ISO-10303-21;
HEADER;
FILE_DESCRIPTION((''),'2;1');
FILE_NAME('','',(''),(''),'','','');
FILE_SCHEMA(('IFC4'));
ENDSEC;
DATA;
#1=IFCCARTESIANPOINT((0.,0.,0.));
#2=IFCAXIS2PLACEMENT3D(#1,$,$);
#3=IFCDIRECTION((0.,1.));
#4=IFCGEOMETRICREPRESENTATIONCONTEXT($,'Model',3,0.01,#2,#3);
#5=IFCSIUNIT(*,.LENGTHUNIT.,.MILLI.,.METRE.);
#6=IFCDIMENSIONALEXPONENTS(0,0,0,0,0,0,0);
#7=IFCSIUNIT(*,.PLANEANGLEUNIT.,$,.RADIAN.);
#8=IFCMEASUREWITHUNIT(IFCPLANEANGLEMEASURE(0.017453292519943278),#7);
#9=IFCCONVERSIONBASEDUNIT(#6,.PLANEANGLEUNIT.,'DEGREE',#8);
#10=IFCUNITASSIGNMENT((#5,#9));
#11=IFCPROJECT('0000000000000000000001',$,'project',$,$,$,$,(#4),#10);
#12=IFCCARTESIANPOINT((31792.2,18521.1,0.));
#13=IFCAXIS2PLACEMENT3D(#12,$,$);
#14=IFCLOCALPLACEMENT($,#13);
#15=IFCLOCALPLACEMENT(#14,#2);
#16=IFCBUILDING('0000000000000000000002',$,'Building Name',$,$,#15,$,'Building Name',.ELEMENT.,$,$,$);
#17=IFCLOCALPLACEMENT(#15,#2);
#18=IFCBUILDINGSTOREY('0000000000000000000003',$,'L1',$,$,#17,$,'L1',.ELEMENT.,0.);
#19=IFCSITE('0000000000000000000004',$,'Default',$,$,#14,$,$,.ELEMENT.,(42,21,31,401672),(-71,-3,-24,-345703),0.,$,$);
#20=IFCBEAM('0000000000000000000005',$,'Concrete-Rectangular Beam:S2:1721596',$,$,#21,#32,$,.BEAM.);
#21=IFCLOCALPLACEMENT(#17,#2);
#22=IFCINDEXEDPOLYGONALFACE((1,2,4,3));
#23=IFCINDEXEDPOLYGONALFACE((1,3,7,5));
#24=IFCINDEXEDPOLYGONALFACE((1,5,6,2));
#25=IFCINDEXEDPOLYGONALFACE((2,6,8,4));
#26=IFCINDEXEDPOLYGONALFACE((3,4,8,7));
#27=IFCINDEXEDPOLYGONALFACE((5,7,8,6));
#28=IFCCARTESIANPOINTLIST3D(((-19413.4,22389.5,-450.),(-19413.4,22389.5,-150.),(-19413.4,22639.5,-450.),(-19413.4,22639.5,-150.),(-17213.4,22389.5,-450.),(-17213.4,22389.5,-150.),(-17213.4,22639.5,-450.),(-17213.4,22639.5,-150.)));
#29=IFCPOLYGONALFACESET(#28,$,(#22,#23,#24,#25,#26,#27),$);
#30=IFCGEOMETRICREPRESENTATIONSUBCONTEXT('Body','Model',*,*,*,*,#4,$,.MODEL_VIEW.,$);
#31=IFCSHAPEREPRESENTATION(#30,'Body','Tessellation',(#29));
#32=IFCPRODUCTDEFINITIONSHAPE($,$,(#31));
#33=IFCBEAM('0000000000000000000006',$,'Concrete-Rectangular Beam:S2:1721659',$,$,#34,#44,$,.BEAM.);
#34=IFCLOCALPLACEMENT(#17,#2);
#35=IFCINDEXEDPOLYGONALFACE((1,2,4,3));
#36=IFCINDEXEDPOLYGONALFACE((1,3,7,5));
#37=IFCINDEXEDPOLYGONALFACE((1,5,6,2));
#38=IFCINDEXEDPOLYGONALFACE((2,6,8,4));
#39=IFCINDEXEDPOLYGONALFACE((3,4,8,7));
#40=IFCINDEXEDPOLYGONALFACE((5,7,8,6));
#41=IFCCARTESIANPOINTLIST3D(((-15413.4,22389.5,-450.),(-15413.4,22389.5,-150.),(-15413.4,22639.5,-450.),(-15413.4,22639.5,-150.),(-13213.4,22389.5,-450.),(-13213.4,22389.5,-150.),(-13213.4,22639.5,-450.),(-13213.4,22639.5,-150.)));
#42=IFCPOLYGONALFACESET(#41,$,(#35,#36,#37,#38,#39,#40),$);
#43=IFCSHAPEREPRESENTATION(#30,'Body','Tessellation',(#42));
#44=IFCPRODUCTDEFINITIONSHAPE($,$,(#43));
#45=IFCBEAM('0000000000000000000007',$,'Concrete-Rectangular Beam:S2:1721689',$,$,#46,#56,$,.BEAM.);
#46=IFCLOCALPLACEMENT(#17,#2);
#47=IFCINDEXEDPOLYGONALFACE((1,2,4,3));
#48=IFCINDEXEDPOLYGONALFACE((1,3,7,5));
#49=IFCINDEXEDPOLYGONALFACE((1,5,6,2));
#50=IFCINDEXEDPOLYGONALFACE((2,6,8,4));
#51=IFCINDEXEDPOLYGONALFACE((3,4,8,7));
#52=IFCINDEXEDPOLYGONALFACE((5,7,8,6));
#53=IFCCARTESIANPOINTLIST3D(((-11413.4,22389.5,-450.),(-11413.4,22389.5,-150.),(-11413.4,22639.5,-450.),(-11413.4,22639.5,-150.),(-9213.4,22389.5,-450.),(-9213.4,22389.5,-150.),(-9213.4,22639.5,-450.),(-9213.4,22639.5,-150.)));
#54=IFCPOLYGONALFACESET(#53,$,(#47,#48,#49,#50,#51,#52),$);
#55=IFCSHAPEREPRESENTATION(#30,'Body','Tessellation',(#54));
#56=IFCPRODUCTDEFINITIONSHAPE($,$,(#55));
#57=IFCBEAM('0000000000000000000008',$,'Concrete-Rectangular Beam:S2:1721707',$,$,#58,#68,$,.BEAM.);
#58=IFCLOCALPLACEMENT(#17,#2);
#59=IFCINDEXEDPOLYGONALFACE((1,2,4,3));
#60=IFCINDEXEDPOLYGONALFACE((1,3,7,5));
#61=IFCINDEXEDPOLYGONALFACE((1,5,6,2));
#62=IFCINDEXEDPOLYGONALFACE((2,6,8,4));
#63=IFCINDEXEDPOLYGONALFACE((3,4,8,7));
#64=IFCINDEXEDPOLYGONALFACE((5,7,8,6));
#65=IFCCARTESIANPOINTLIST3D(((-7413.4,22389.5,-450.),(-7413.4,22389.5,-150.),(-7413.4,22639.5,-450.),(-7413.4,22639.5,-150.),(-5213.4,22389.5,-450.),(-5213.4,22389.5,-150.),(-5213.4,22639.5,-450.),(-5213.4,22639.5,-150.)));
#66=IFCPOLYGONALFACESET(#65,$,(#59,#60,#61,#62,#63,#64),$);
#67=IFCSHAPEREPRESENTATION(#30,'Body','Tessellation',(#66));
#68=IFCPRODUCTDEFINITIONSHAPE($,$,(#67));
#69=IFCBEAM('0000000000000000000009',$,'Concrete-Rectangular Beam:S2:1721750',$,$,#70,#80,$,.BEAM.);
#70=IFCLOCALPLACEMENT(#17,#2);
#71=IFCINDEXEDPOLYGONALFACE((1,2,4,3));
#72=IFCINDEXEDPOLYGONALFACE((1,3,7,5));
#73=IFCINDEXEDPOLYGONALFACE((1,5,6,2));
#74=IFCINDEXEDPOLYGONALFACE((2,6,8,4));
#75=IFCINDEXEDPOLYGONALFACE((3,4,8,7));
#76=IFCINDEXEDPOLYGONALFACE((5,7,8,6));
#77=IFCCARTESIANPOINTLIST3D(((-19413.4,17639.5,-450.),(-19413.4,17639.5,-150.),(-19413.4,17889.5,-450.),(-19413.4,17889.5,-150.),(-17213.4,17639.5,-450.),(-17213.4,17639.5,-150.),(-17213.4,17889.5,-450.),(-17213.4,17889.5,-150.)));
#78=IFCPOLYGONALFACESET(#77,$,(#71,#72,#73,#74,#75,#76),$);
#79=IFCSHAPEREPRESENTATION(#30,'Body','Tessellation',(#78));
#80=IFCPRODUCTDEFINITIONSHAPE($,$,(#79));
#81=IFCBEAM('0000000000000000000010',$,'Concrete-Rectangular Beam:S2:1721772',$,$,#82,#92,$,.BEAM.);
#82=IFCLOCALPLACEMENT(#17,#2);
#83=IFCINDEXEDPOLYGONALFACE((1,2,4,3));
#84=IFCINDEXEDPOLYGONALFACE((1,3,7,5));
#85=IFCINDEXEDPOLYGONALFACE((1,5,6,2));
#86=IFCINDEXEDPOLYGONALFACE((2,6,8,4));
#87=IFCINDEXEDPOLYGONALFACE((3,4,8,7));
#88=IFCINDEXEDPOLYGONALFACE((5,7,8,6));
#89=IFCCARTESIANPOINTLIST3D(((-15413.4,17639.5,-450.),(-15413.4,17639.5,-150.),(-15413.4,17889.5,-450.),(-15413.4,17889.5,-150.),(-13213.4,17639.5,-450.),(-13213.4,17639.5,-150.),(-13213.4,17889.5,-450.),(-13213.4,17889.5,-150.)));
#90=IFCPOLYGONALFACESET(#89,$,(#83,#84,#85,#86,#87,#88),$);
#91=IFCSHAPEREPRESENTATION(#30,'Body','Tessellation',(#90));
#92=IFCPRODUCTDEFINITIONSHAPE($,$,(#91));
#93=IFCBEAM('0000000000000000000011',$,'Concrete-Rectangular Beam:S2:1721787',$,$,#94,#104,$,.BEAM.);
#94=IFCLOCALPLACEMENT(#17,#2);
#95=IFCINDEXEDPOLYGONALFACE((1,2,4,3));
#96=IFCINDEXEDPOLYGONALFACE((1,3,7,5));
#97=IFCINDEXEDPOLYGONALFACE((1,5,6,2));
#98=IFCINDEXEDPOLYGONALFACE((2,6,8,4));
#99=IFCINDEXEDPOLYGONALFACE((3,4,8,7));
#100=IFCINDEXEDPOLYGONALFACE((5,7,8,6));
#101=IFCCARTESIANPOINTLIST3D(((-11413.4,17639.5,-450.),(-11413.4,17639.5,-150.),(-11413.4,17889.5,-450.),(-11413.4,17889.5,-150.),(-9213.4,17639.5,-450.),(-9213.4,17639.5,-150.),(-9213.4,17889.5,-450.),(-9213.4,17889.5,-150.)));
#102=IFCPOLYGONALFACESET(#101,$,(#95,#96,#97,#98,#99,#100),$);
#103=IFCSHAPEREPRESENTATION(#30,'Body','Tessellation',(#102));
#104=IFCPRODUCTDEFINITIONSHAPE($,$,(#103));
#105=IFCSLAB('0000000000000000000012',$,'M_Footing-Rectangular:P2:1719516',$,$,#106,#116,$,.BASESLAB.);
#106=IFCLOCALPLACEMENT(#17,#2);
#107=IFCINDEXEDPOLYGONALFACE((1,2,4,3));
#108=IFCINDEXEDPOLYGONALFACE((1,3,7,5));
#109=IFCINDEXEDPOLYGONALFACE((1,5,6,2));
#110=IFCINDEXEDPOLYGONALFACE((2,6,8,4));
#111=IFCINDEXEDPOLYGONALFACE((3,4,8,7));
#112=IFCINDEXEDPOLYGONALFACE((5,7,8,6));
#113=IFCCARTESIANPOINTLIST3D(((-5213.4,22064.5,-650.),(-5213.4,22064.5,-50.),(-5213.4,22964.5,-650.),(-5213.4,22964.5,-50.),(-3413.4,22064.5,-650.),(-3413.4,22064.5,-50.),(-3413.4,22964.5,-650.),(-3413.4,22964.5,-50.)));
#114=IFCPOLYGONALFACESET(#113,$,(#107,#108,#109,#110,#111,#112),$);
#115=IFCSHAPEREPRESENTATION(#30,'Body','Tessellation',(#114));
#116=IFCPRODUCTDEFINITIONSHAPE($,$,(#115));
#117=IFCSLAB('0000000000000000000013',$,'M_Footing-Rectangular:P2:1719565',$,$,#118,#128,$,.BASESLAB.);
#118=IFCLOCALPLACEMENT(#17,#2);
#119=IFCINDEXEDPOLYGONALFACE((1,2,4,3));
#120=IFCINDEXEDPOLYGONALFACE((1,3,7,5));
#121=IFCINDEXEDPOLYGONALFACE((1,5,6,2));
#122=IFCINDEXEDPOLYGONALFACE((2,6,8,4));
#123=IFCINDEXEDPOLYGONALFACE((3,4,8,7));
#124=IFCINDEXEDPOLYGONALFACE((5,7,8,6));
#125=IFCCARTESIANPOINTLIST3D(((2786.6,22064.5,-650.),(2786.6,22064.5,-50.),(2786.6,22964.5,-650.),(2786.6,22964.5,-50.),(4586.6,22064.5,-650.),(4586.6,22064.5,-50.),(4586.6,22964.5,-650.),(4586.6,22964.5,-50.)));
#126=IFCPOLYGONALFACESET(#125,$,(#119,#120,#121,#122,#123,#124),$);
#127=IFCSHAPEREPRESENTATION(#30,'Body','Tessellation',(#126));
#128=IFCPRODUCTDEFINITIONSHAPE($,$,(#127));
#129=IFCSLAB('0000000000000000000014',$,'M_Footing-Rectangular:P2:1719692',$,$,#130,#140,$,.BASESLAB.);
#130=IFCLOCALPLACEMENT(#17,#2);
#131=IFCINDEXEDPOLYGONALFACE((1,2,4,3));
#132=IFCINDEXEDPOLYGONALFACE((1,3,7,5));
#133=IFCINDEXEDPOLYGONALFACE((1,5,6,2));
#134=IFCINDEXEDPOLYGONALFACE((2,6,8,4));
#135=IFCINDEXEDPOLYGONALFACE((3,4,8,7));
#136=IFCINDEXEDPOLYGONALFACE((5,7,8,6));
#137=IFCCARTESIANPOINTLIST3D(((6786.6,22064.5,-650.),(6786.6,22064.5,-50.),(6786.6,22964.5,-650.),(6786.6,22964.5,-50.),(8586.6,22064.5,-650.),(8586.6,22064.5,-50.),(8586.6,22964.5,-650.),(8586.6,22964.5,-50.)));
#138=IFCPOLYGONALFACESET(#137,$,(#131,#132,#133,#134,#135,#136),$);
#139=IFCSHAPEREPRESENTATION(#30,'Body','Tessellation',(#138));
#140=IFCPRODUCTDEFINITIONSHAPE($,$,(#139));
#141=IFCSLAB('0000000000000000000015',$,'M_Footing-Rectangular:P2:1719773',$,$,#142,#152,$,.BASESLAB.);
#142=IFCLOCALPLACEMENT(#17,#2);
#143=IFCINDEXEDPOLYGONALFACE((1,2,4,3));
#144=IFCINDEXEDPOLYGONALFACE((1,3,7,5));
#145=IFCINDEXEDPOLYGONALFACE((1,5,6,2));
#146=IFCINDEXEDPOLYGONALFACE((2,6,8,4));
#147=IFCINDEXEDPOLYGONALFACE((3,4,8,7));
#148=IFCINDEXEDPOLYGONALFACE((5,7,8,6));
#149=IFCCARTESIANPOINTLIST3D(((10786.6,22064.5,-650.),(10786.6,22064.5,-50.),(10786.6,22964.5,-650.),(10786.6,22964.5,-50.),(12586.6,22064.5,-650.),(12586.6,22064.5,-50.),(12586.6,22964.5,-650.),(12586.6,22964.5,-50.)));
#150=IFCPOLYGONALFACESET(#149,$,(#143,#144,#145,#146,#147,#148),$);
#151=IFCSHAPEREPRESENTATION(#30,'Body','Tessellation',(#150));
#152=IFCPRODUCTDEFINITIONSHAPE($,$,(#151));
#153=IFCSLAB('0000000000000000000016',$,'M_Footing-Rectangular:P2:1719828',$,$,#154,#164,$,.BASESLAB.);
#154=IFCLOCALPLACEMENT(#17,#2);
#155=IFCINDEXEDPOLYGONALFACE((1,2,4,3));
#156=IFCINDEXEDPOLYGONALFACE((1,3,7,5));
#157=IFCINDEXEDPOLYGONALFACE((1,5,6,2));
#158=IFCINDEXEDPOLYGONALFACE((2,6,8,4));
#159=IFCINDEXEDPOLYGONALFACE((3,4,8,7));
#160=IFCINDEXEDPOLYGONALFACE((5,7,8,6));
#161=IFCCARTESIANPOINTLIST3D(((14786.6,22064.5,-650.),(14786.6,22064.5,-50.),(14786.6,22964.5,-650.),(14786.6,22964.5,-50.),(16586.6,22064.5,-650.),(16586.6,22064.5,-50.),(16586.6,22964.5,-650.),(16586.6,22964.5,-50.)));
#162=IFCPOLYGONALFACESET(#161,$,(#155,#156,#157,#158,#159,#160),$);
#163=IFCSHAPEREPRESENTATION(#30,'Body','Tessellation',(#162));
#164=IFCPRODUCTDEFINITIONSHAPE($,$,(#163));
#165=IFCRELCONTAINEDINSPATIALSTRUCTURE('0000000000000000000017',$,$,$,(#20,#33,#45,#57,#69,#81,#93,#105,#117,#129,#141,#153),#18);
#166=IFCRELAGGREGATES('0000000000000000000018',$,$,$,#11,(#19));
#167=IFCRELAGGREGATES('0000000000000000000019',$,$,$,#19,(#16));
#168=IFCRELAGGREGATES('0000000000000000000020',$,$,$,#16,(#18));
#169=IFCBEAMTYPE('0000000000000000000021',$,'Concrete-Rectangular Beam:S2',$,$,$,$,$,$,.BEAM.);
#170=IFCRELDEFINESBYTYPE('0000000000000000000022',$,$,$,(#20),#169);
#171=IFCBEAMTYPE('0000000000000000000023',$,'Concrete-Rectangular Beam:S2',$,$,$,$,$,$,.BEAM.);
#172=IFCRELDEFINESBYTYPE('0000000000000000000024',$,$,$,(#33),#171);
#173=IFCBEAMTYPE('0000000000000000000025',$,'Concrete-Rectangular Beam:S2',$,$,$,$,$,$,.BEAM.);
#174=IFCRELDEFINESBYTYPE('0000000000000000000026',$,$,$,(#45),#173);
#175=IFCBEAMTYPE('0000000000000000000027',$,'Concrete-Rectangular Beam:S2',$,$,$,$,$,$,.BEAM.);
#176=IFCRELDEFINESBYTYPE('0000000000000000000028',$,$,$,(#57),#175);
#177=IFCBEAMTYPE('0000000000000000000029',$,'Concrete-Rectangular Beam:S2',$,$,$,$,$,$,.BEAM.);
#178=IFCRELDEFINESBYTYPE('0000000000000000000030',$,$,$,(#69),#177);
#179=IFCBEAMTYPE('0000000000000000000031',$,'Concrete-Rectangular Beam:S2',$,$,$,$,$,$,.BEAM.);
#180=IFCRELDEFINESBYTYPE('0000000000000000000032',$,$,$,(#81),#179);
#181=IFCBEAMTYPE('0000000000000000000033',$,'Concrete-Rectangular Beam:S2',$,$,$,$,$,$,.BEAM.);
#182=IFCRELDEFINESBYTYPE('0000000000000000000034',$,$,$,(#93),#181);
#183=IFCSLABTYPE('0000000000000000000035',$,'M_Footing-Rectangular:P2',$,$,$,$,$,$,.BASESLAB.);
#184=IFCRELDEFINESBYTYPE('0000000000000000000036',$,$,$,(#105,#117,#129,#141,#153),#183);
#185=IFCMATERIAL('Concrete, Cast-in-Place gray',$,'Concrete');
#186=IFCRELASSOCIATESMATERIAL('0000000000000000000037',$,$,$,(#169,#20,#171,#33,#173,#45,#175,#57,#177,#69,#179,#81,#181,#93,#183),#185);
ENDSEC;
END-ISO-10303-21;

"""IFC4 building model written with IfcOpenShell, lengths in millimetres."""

from ifc_helpers import new_model, entity, si_unit, converted_unit, direction, frame, origin, place, context, subcontext, project, spatial, indexed_curve, outline, extrude, source, transform, mapped, material, type_object, type_shapes, element, save


model = new_model("IFC4")

# Units and contexts
model_context = context("Model", 3, precision=0.01, world=origin(), true_north=direction((0.0, 1.0)))
body_context = subcontext(model_context, "Body", "Model", "MODEL_VIEW")
ifc_project = project(units=[si_unit("LENGTHUNIT", "METRE", prefix="MILLI"), converted_unit("PLANEANGLEUNIT", "DEGREE", entity("IfcPlaneAngleMeasure", 0.017453292519943278), si_unit("PLANEANGLEUNIT", "RADIAN"), dimensions=[0, 0, 0, 0, 0, 0, 0])], contexts=[model_context])

# Site, building, storey
site_placement = place(None, frame((31792.2, 18521.1, 0.0)))
site = spatial("IfcSite", under=ifc_project, at=site_placement, Name="Default", CompositionType="ELEMENT", RefLatitude=(42, 21, 31, 401672), RefLongitude=(-71, -3, -24, -345703), RefElevation=0.0)
building_placement = place(site_placement, origin())
building = spatial("IfcBuilding", under=site, at=building_placement, Name="Building Name", LongName="Building Name", CompositionType="ELEMENT")
storey_placement = place(building_placement, origin())
storey = spatial("IfcBuildingStorey", under=building, at=storey_placement, Name="L1", LongName="L1", CompositionType="ELEMENT", Elevation=0.0)

# Beams
ifc_material = material(Name="Concrete, Cast-in-Place gray", Category="Concrete")
beam_type_1 = type_object("IfcBeamType", Name="Concrete-Rectangular Beam:S2", PredefinedType="BEAM", material=ifc_material)
shared_shape_1 = source(origin(), body_context, "Body", "SweptSolid", [
    extrude(outline(indexed_curve([(-150.0, -125.0), (150.0, -125.0), (150.0, 125.0), (-150.0, 125.0), (-150.0, -125.0)], self_intersect=False)), frame((-19413.4, 22514.5, -300.0), z_axis=(1.0, 0.0, 0.0), x_axis=(0.0, 0.0, -1.0)), (0.0, 0.0, 1.0), 2200.0),
])
type_shapes(beam_type_1, [shared_shape_1])
beam_1_placement = place(storey_placement, origin())
element("IfcBeam", 1, at=beam_1_placement, inside=storey, type_object=beam_type_1, material=ifc_material, Name="Concrete-Rectangular Beam:S2:1721596", PredefinedType="BEAM", context=body_context, shape_type="MappedRepresentation", body=[
    mapped(shared_shape_1, transform((0.0, 0.0, 0.0), scale=1.0)),
])
beam_type_2 = type_object("IfcBeamType", Name="Concrete-Rectangular Beam:S2", PredefinedType="BEAM", material=ifc_material)
shared_shape_2 = source(origin(), body_context, "Body", "SweptSolid", [
    extrude(outline(indexed_curve([(-150.0, -125.0), (150.0, -125.0), (150.0, 125.0), (-150.0, 125.0), (-150.0, -125.0)], self_intersect=False)), frame((-13213.4, 22514.5, -300.0), z_axis=(-1.0, 0.0, 0.0), x_axis=(0.0, 0.0, -1.0)), (0.0, 0.0, 1.0), 2200.0),
])
type_shapes(beam_type_2, [shared_shape_2])
beam_2_placement = place(storey_placement, origin())
element("IfcBeam", 2, at=beam_2_placement, inside=storey, type_object=beam_type_2, material=ifc_material, Name="Concrete-Rectangular Beam:S2:1721659", PredefinedType="BEAM", context=body_context, shape_type="MappedRepresentation", body=[
    mapped(shared_shape_2, transform((0.0, 0.0, 0.0), scale=1.0)),
])
beam_type_3 = type_object("IfcBeamType", Name="Concrete-Rectangular Beam:S2", PredefinedType="BEAM", material=ifc_material)
shared_shape_3 = source(origin(), body_context, "Body", "SweptSolid", [
    extrude(outline(indexed_curve([(-150.0, -125.0), (150.0, -125.0), (150.0, 125.0), (-150.0, 125.0), (-150.0, -125.0)], self_intersect=False)), frame((-11413.4, 22514.5, -300.0), z_axis=(1.0, 0.0, 0.0), x_axis=(0.0, 0.0, -1.0)), (0.0, 0.0, 1.0), 2200.0),
])
type_shapes(beam_type_3, [shared_shape_3])
beam_3_placement = place(storey_placement, origin())
element("IfcBeam", 3, at=beam_3_placement, inside=storey, type_object=beam_type_3, material=ifc_material, Name="Concrete-Rectangular Beam:S2:1721689", PredefinedType="BEAM", context=body_context, shape_type="MappedRepresentation", body=[
    mapped(shared_shape_3, transform((0.0, 0.0, 0.0), scale=1.0)),
])
beam_type_4 = type_object("IfcBeamType", Name="Concrete-Rectangular Beam:S2", PredefinedType="BEAM", material=ifc_material)
shared_shape_4 = source(origin(), body_context, "Body", "SweptSolid", [
    extrude(outline(indexed_curve([(-150.0, -125.0), (150.0, -125.0), (150.0, 125.0), (-150.0, 125.0), (-150.0, -125.0)], self_intersect=False)), frame((-7413.4, 22514.5, -300.0), z_axis=(1.0, 0.0, 0.0), x_axis=(0.0, 0.0, -1.0)), (0.0, 0.0, 1.0), 2200.0),
])
type_shapes(beam_type_4, [shared_shape_4])
beam_4_placement = place(storey_placement, origin())
element("IfcBeam", 4, at=beam_4_placement, inside=storey, type_object=beam_type_4, material=ifc_material, Name="Concrete-Rectangular Beam:S2:1721707", PredefinedType="BEAM", context=body_context, shape_type="MappedRepresentation", body=[
    mapped(shared_shape_4, transform((0.0, 0.0, 0.0), scale=1.0)),
])
beam_type_5 = type_object("IfcBeamType", Name="Concrete-Rectangular Beam:S2", PredefinedType="BEAM", material=ifc_material)
shared_shape_5 = source(origin(), body_context, "Body", "SweptSolid", [
    extrude(outline(indexed_curve([(-150.0, -125.0), (150.0, -125.0), (150.0, 125.0), (-150.0, 125.0), (-150.0, -125.0)], self_intersect=False)), frame((-19413.4, 17764.5, -300.0), z_axis=(1.0, 0.0, 0.0), x_axis=(0.0, 0.0, -1.0)), (0.0, 0.0, 1.0), 2200.0),
])
type_shapes(beam_type_5, [shared_shape_5])
beam_5_placement = place(storey_placement, origin())
element("IfcBeam", 5, at=beam_5_placement, inside=storey, type_object=beam_type_5, material=ifc_material, Name="Concrete-Rectangular Beam:S2:1721750", PredefinedType="BEAM", context=body_context, shape_type="MappedRepresentation", body=[
    mapped(shared_shape_5, transform((0.0, 0.0, 0.0), scale=1.0)),
])
beam_type_6 = type_object("IfcBeamType", Name="Concrete-Rectangular Beam:S2", PredefinedType="BEAM", material=ifc_material)
shared_shape_6 = source(origin(), body_context, "Body", "SweptSolid", [
    extrude(outline(indexed_curve([(-150.0, -125.0), (150.0, -125.0), (150.0, 125.0), (-150.0, 125.0), (-150.0, -125.0)], self_intersect=False)), frame((-15413.4, 17764.5, -300.0), z_axis=(1.0, 0.0, 0.0), x_axis=(0.0, 0.0, -1.0)), (0.0, 0.0, 1.0), 2200.0),
])
type_shapes(beam_type_6, [shared_shape_6])
beam_6_placement = place(storey_placement, origin())
element("IfcBeam", 6, at=beam_6_placement, inside=storey, type_object=beam_type_6, material=ifc_material, Name="Concrete-Rectangular Beam:S2:1721772", PredefinedType="BEAM", context=body_context, shape_type="MappedRepresentation", body=[
    mapped(shared_shape_6, transform((0.0, 0.0, 0.0), scale=1.0)),
])
beam_type_7 = type_object("IfcBeamType", Name="Concrete-Rectangular Beam:S2", PredefinedType="BEAM", material=ifc_material)
shared_shape_7 = source(origin(), body_context, "Body", "SweptSolid", [
    extrude(outline(indexed_curve([(-150.0, -125.0), (150.0, -125.0), (150.0, 125.0), (-150.0, 125.0), (-150.0, -125.0)], self_intersect=False)), frame((-11413.4, 17764.5, -300.0), z_axis=(1.0, 0.0, 0.0), x_axis=(0.0, 0.0, -1.0)), (0.0, 0.0, 1.0), 2200.0),
])
type_shapes(beam_type_7, [shared_shape_7])
beam_7_placement = place(storey_placement, origin())
element("IfcBeam", 7, at=beam_7_placement, inside=storey, type_object=beam_type_7, material=ifc_material, Name="Concrete-Rectangular Beam:S2:1721787", PredefinedType="BEAM", context=body_context, shape_type="MappedRepresentation", body=[
    mapped(shared_shape_7, transform((0.0, 0.0, 0.0), scale=1.0)),
])

# Slabs
slab_type = type_object("IfcSlabType", Name="M_Footing-Rectangular:P2", PredefinedType="BASESLAB", material=ifc_material)
slab_1_placement = place(storey_placement, origin())
element("IfcSlab", 8, at=slab_1_placement, inside=storey, type_object=slab_type, Name="M_Footing-Rectangular:P2:1719516", PredefinedType="BASESLAB", context=body_context, shape_type="SweptSolid", body=[
    extrude(outline(indexed_curve([(-450.0, -900.0), (450.0, -900.0), (450.0, 900.0), (-450.0, 900.0), (-450.0, -900.0)], self_intersect=False)), frame((-4313.4, 22514.5, -650.0), z_axis=(0.0, 0.0, 1.0), x_axis=(0.0, -1.0, 0.0)), (0.0, 0.0, 1.0), 600.0),
])
slab_2_placement = place(storey_placement, origin())
element("IfcSlab", 9, at=slab_2_placement, inside=storey, type_object=slab_type, Name="M_Footing-Rectangular:P2:1719565", PredefinedType="BASESLAB", context=body_context, shape_type="SweptSolid", body=[
    extrude(outline(indexed_curve([(-450.0, -900.0), (450.0, -900.0), (450.0, 900.0), (-450.0, 900.0), (-450.0, -900.0)], self_intersect=False)), frame((3686.6, 22514.5, -650.0), z_axis=(0.0, 0.0, 1.0), x_axis=(0.0, -1.0, 0.0)), (0.0, 0.0, 1.0), 600.0),
])
slab_3_placement = place(storey_placement, origin())
element("IfcSlab", 10, at=slab_3_placement, inside=storey, type_object=slab_type, Name="M_Footing-Rectangular:P2:1719692", PredefinedType="BASESLAB", context=body_context, shape_type="SweptSolid", body=[
    extrude(outline(indexed_curve([(-450.0, -900.0), (450.0, -900.0), (450.0, 900.0), (-450.0, 900.0), (-450.0, -900.0)], self_intersect=False)), frame((7686.6, 22514.5, -650.0), z_axis=(0.0, 0.0, 1.0), x_axis=(0.0, -1.0, 0.0)), (0.0, 0.0, 1.0), 600.0),
])
slab_4_placement = place(storey_placement, origin())
element("IfcSlab", 11, at=slab_4_placement, inside=storey, type_object=slab_type, Name="M_Footing-Rectangular:P2:1719773", PredefinedType="BASESLAB", context=body_context, shape_type="SweptSolid", body=[
    extrude(outline(indexed_curve([(-450.0, -900.0), (450.0, -900.0), (450.0, 900.0), (-450.0, 900.0), (-450.0, -900.0)], self_intersect=False)), frame((11686.6, 22514.5, -650.0), z_axis=(0.0, 0.0, 1.0), x_axis=(0.0, -1.0, 0.0)), (0.0, 0.0, 1.0), 600.0),
])
slab_5_placement = place(storey_placement, origin())
element("IfcSlab", 12, at=slab_5_placement, inside=storey, type_object=slab_type, Name="M_Footing-Rectangular:P2:1719828", PredefinedType="BASESLAB", context=body_context, shape_type="SweptSolid", body=[
    extrude(outline(indexed_curve([(-450.0, -900.0), (450.0, -900.0), (450.0, 900.0), (-450.0, 900.0), (-450.0, -900.0)], self_intersect=False)), frame((15686.6, 22514.5, -650.0), z_axis=(0.0, 0.0, 1.0), x_axis=(0.0, -1.0, 0.0)), (0.0, 0.0, 1.0), 600.0),
])

save(model, "model.ifc")
